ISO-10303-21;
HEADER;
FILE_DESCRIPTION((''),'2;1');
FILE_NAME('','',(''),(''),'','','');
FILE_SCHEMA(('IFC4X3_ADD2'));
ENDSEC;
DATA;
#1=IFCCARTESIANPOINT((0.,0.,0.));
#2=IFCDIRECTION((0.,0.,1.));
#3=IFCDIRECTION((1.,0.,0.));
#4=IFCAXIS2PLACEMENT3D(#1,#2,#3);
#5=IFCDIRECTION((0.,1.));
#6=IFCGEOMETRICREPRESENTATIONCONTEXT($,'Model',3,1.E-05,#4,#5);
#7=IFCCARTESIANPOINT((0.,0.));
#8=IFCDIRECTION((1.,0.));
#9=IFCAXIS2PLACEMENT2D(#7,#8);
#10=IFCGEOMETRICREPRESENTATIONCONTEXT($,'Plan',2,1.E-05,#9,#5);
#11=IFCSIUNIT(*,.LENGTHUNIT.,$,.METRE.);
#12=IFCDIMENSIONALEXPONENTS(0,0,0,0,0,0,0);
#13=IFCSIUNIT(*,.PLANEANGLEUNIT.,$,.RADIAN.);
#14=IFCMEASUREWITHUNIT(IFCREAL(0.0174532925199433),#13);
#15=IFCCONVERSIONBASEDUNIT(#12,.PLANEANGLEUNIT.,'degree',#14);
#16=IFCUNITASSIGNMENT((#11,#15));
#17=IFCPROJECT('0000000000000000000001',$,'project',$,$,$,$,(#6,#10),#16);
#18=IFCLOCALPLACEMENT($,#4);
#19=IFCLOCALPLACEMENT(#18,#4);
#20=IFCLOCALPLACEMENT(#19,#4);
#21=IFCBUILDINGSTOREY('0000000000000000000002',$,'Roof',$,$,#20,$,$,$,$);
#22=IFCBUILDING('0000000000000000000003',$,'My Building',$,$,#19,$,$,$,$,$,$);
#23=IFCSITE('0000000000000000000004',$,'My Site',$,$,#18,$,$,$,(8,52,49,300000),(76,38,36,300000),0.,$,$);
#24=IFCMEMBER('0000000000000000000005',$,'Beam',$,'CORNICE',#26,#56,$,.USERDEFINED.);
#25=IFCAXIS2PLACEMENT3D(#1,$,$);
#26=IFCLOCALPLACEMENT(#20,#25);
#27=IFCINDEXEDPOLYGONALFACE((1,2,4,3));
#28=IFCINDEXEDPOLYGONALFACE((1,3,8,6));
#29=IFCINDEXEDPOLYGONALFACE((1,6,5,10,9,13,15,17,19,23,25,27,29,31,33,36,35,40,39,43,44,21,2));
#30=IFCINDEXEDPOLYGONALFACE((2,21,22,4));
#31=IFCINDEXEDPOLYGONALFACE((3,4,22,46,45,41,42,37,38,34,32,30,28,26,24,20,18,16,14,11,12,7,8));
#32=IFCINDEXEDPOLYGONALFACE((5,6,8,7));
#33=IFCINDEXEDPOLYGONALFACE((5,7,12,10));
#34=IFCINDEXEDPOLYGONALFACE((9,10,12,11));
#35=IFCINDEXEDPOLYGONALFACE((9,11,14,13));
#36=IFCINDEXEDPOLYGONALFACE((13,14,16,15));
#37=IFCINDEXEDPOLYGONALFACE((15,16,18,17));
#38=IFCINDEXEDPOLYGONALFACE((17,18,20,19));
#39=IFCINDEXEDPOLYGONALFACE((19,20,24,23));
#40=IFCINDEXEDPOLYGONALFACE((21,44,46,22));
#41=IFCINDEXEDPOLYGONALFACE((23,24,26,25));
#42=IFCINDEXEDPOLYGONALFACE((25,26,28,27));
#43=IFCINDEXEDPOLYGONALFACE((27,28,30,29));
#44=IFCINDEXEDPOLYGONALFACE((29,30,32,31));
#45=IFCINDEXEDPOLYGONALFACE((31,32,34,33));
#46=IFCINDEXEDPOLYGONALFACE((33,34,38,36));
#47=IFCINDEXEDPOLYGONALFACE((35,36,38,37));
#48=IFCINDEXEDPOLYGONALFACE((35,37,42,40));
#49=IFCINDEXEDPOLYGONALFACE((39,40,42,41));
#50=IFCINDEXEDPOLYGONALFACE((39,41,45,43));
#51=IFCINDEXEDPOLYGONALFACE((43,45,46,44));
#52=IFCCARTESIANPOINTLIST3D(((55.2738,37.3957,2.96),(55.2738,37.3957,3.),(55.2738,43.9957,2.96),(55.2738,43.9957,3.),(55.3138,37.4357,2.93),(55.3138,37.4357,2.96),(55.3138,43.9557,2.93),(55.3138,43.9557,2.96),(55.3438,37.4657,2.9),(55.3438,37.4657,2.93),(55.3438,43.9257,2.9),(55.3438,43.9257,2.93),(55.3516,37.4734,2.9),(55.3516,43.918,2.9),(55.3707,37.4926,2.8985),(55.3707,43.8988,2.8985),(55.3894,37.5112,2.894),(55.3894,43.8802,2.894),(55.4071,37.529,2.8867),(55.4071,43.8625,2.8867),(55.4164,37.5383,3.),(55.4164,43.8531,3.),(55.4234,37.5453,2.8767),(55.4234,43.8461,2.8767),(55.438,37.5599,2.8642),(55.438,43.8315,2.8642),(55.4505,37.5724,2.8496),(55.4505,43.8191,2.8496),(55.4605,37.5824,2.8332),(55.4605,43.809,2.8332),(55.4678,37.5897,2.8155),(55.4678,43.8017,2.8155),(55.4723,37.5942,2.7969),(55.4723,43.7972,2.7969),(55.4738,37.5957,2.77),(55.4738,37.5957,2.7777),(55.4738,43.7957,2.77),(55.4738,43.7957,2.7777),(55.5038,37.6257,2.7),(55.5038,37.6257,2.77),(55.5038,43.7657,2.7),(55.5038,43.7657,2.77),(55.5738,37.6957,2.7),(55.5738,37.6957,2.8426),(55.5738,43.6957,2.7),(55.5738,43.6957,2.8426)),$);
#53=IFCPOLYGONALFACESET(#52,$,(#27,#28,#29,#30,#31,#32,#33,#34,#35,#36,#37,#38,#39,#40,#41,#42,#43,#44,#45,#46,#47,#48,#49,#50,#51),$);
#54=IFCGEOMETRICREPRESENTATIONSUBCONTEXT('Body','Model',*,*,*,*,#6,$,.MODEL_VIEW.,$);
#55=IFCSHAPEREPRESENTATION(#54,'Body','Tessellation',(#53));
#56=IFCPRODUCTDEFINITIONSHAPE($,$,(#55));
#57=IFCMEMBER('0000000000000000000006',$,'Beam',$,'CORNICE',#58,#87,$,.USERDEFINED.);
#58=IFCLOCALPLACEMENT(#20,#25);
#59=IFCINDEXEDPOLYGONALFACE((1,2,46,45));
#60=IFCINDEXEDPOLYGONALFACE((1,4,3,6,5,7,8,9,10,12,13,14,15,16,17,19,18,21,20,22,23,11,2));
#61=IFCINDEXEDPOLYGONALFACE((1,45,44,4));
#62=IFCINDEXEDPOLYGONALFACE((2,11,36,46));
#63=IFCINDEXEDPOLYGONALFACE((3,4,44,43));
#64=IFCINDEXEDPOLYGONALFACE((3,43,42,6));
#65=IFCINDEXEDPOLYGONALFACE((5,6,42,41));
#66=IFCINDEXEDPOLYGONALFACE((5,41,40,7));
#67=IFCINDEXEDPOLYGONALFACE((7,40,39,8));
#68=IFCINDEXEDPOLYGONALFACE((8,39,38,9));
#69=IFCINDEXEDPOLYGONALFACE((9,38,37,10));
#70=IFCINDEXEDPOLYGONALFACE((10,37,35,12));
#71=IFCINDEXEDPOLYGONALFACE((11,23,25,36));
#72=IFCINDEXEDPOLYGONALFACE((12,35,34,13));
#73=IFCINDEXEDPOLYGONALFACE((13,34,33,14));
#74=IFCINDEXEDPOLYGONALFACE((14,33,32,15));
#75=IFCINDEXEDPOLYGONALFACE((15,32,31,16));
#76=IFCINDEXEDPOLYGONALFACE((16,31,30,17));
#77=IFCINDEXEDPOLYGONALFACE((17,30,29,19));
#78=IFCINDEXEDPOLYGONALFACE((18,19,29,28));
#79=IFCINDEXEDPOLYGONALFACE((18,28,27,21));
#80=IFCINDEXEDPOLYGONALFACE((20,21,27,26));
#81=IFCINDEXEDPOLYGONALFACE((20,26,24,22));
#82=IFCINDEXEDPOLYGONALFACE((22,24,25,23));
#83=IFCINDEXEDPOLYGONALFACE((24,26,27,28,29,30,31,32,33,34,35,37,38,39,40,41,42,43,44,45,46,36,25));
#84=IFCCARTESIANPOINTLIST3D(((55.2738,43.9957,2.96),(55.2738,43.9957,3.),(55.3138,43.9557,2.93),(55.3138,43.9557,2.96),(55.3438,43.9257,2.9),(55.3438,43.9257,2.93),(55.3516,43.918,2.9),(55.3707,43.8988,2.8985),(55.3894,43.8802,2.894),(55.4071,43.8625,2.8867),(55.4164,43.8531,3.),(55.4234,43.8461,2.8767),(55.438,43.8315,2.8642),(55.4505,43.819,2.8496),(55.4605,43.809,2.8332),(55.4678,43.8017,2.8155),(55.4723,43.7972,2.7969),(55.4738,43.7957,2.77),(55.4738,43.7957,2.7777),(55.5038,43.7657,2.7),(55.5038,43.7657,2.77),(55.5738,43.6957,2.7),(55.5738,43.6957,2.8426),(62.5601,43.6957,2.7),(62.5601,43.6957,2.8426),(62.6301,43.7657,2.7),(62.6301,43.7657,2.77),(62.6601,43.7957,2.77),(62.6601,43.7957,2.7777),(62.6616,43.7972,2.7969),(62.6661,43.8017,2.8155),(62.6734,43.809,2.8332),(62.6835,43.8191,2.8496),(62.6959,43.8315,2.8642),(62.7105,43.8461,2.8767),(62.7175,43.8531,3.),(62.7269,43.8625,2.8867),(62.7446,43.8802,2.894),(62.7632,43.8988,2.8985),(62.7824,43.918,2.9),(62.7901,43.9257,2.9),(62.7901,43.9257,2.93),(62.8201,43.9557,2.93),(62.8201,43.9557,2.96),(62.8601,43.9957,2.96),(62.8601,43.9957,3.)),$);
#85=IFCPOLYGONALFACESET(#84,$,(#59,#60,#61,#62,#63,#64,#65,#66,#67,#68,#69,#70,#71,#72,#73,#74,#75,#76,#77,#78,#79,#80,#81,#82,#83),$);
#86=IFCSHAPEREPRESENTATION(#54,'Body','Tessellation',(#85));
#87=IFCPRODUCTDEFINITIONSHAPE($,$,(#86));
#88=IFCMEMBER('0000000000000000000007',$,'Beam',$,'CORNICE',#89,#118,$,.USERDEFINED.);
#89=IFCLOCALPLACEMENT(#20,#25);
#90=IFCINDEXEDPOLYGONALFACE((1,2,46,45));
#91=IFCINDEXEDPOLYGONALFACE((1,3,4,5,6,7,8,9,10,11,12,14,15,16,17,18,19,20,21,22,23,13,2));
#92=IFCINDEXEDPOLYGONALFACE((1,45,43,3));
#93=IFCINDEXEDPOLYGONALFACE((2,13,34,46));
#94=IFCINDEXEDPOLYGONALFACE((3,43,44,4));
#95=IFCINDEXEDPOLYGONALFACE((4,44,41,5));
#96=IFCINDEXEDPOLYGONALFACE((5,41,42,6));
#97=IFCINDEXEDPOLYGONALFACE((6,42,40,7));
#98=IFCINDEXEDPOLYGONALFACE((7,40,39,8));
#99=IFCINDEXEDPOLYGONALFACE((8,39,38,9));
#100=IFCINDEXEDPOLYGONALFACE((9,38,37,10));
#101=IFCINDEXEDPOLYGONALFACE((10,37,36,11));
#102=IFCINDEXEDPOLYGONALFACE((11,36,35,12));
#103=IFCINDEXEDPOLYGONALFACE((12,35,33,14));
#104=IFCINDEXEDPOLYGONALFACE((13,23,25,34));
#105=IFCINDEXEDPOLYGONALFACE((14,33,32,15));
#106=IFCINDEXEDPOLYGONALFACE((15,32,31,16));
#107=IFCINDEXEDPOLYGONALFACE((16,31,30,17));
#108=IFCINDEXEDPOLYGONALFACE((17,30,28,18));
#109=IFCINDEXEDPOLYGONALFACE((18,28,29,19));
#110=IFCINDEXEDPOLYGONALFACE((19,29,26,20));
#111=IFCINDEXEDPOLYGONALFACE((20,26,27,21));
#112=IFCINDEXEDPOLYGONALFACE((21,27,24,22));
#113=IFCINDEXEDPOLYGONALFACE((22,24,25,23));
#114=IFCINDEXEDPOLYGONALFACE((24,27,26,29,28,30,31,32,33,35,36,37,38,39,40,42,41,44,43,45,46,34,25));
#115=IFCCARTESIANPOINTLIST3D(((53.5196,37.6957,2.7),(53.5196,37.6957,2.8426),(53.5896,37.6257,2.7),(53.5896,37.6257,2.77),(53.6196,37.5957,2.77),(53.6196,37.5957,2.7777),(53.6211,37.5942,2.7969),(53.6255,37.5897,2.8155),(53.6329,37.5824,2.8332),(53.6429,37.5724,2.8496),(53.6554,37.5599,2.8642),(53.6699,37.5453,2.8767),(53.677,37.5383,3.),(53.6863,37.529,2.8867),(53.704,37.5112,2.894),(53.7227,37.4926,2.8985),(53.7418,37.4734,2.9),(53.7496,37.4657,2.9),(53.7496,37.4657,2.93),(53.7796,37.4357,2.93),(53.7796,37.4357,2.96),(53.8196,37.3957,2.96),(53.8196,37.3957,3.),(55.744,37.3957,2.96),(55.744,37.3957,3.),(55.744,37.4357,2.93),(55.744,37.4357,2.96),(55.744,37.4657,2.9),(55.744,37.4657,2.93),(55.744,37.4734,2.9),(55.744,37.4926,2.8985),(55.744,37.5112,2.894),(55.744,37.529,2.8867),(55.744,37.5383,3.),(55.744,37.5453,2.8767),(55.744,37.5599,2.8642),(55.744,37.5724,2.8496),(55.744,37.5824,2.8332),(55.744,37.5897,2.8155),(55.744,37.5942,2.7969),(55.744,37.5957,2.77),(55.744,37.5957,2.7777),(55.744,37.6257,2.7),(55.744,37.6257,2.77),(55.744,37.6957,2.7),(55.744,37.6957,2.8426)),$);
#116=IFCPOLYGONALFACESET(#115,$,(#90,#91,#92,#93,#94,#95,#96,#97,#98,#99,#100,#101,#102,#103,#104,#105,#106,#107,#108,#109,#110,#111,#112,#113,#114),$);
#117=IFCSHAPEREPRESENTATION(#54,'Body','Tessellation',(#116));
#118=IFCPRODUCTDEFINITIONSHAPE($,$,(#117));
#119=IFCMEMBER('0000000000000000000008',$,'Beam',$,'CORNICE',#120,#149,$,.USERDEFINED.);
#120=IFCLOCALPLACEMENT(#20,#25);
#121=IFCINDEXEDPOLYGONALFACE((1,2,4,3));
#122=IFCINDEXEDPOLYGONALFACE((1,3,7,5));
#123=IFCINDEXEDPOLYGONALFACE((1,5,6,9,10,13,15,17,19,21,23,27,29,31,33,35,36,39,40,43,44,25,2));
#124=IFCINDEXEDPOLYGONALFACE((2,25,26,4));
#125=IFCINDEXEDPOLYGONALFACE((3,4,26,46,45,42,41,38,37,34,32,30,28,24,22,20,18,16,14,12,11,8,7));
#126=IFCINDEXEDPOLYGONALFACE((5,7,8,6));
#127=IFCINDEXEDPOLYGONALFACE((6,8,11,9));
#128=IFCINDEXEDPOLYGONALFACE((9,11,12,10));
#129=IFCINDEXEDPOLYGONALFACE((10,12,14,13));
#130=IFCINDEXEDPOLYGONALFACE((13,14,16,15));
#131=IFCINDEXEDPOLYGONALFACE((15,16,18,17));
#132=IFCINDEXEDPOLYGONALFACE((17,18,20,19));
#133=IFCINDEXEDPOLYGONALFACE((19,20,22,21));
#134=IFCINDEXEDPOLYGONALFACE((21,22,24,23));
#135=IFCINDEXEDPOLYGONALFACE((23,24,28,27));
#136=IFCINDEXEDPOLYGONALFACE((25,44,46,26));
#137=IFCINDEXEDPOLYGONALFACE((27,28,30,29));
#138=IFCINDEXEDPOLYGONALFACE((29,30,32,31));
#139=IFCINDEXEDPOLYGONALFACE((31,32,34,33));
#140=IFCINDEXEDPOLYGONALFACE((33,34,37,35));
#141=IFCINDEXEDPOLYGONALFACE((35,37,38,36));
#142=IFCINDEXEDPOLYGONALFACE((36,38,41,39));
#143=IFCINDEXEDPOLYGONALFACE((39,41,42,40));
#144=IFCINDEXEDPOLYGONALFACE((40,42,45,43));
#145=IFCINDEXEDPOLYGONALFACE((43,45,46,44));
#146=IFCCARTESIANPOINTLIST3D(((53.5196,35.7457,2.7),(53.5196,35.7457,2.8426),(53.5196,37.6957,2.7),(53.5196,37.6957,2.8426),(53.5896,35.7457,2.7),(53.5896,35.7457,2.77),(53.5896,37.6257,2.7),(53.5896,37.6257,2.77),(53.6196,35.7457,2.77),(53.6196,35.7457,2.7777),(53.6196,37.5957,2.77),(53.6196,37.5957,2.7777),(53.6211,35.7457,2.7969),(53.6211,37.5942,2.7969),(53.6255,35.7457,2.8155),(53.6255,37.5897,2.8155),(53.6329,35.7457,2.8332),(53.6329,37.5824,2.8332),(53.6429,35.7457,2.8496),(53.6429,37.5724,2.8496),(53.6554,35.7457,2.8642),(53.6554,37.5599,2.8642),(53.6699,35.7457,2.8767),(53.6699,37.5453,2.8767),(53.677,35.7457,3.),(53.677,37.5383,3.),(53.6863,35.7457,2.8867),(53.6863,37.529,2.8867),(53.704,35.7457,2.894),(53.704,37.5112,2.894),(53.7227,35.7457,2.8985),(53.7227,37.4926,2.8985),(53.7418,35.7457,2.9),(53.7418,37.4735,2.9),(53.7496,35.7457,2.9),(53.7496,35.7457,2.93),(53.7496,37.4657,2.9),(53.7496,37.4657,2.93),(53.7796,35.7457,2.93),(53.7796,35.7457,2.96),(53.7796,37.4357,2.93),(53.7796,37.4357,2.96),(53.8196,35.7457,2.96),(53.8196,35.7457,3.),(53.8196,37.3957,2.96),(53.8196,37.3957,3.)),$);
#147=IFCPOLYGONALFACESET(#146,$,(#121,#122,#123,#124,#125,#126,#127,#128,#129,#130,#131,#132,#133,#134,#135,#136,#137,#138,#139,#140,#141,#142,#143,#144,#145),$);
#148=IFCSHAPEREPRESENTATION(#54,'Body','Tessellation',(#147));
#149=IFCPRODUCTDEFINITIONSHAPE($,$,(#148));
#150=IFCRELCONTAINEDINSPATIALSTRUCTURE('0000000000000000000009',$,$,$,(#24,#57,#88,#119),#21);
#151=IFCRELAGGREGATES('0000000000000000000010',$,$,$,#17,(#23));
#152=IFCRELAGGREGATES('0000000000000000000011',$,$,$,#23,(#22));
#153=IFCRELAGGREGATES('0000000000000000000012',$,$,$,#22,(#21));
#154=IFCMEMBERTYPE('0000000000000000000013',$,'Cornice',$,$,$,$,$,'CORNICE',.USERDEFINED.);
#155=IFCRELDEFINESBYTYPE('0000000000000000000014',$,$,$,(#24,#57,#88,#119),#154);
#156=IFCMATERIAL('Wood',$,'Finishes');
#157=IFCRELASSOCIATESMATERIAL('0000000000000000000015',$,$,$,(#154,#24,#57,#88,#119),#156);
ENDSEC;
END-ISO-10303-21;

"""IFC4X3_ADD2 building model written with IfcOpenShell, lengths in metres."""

from ifc_helpers import new_model, entity, si_unit, converted_unit, direction, frame, origin_with_axes, origin_2d_with_axis, place, context, subcontext, project, spatial, indexed_curve, outline, extrude, clip, halfspace, material, material_profile, profile_set, profile_usage, type_object, element, save


model = new_model("IFC4X3_ADD2")

# Units and contexts
model_context = context("Model", 3, precision=1e-05, world=origin_with_axes(), true_north=direction((0.0, 1.0)))
plan_context = context("Plan", 2, precision=1e-05, world=origin_2d_with_axis(), true_north=direction((0.0, 1.0)))
body_context = subcontext(model_context, "Body", "Model", "MODEL_VIEW")
ifc_project = project(units=[si_unit("LENGTHUNIT", "METRE"), converted_unit("PLANEANGLEUNIT", "degree", entity("IfcReal", 0.0174532925199433), si_unit("PLANEANGLEUNIT", "RADIAN"), dimensions=[0, 0, 0, 0, 0, 0, 0])], contexts=[model_context, plan_context])

# Site, building, storey
site_placement = place(None, origin_with_axes())
site = spatial("IfcSite", under=ifc_project, at=site_placement, Name="My Site", RefLatitude=(8, 52, 49, 300000), RefLongitude=(76, 38, 36, 300000), RefElevation=0.0)
building_placement = place(site_placement, origin_with_axes())
building = spatial("IfcBuilding", under=site, at=building_placement, Name="My Building")
storey_placement = place(building_placement, origin_with_axes())
storey = spatial("IfcBuildingStorey", under=building, at=storey_placement, Name="Roof")

# Members
ifc_material_1 = material(Name="Wood", Category="Finishes")
ifc_material_profile_1 = material_profile(ifc_material_1, outline(indexed_curve([(-0.26, 0.26), (-0.3, 0.26), (-0.3, 0.3), (-0.1574, 0.3), (0.0, 0.1426), (0.0, 0.0), (-0.07, 0.0), (-0.07, 0.07), (-0.1, 0.07), (-0.1, 0.0777), (-0.1015, 0.0969), (-0.106, 0.1155), (-0.1133, 0.1332), (-0.1233, 0.1496), (-0.1358, 0.1642), (-0.1504, 0.1767), (-0.1668, 0.1867), (-0.1845, 0.194), (-0.2031, 0.1985), (-0.2223, 0.2), (-0.23, 0.2), (-0.23, 0.23), (-0.26, 0.23), (-0.26, 0.26)])))
ifc_profile_set_1 = profile_set([ifc_material_profile_1])
member_type = type_object("IfcMemberType", Name="Cornice", ElementType="CORNICE", PredefinedType="USERDEFINED", material=ifc_profile_set_1)
ifc_profile_usage_1 = profile_usage(ifc_profile_set_1, cardinal=5)
member_1_placement = place(storey_placement, frame((55.5738, 43.9957, 2.7), z_axis=(0.0, -1.0, 0.0), x_axis=(1.0, 0.0, 0.0)))
element("IfcMember", 1, at=member_1_placement, inside=storey, type_object=member_type, material=ifc_profile_usage_1, Name="Beam", ObjectType="CORNICE", PredefinedType="USERDEFINED", context=body_context, shape_type="Clipping", body=[
    clip(clip(extrude(outline(indexed_curve([(-0.26, 0.26), (-0.3, 0.26), (-0.3, 0.3), (-0.1574, 0.3), (0.0, 0.1426), (0.0, 0.0), (-0.07, 0.0), (-0.07, 0.07), (-0.1, 0.07), (-0.1, 0.0777), (-0.1015, 0.0969), (-0.106, 0.1155), (-0.1133, 0.1332), (-0.1233, 0.1496), (-0.1358, 0.1642), (-0.1504, 0.1767), (-0.1668, 0.1867), (-0.1845, 0.194), (-0.2031, 0.1985), (-0.2223, 0.2), (-0.23, 0.2), (-0.23, 0.23), (-0.26, 0.23), (-0.26, 0.26)])), origin_with_axes(), (0.0, 0.0, 1.0), 6.6), halfspace(frame((-0.3, -2.7, 0.0), z_axis=(0.707107, 0.0, -0.707107), x_axis=(0.0, -1.0, 0.0)), False)), halfspace(frame((-0.3, -2.7, 6.6), z_axis=(0.707107, 0.0, 0.707107), x_axis=(0.0, -1.0, 0.0)), False)),
])
ifc_profile_usage_2 = profile_usage(ifc_profile_set_1, cardinal=5)
member_2_placement = place(storey_placement, frame((62.8601, 43.6957, 2.7), z_axis=(-1.0, 0.0, 0.0), x_axis=(0.0, -1.0, 0.0)))
element("IfcMember", 2, at=member_2_placement, inside=storey, type_object=member_type, material=ifc_profile_usage_2, Name="Beam", ObjectType="CORNICE", PredefinedType="USERDEFINED", context=body_context, shape_type="Clipping", body=[
    clip(clip(extrude(outline(indexed_curve([(-0.26, 0.26), (-0.3, 0.26), (-0.3, 0.3), (-0.1574, 0.3), (0.0, 0.1426), (0.0, 0.0), (-0.07, 0.0), (-0.07, 0.07), (-0.1, 0.07), (-0.1, 0.0777), (-0.1015, 0.0969), (-0.106, 0.1155), (-0.1133, 0.1332), (-0.1233, 0.1496), (-0.1358, 0.1642), (-0.1504, 0.1767), (-0.1668, 0.1867), (-0.1845, 0.194), (-0.2031, 0.1985), (-0.2223, 0.2), (-0.23, 0.2), (-0.23, 0.23), (-0.26, 0.23), (-0.26, 0.26)])), origin_with_axes(), (0.0, 0.0, 1.0), 7.5863), halfspace(frame((-0.3, -2.7, 0.0), z_axis=(0.707107, 0.0, -0.707107), x_axis=(0.0, -1.0, 0.0)), False)), halfspace(frame((-0.3, -2.7, 7.5863), z_axis=(0.707107, 0.0, 0.707107), x_axis=(0.0, -1.0, 0.0)), False)),
])
ifc_profile_usage_3 = profile_usage(ifc_profile_set_1, cardinal=5)
member_3_placement = place(storey_placement, frame((53.5196, 37.6957, 2.7), z_axis=(1.0, 0.0, 0.0), x_axis=(0.0, 1.0, 0.0)))
element("IfcMember", 3, at=member_3_placement, inside=storey, type_object=member_type, material=ifc_profile_usage_3, Name="Beam", ObjectType="CORNICE", PredefinedType="USERDEFINED", context=body_context, shape_type="Clipping", body=[
    clip(extrude(outline(indexed_curve([(-0.26, 0.26), (-0.3, 0.26), (-0.3, 0.3), (-0.1574, 0.3), (0.0, 0.1426), (0.0, 0.0), (-0.07, 0.0), (-0.07, 0.07), (-0.1, 0.07), (-0.1, 0.0777), (-0.1015, 0.0969), (-0.106, 0.1155), (-0.1133, 0.1332), (-0.1233, 0.1496), (-0.1358, 0.1642), (-0.1504, 0.1767), (-0.1668, 0.1867), (-0.1845, 0.194), (-0.2031, 0.1985), (-0.2223, 0.2), (-0.23, 0.2), (-0.23, 0.23), (-0.26, 0.23), (-0.26, 0.26)])), origin_with_axes(), (0.0, 0.0, 1.0), 2.2245), halfspace(frame((0.0, -2.7, 0.0), z_axis=(-0.707107, 0.0, -0.707107), x_axis=(0.0, 1.0, 0.0)), False)),
])
ifc_profile_usage_4 = profile_usage(ifc_profile_set_1, cardinal=5)
member_4_placement = place(storey_placement, frame((53.5196, 35.7457, 2.7), z_axis=(0.0, 1.0, 0.0), x_axis=(-1.0, 0.0, 0.0)))
element("IfcMember", 4, at=member_4_placement, inside=storey, type_object=member_type, material=ifc_profile_usage_4, Name="Beam", ObjectType="CORNICE", PredefinedType="USERDEFINED", context=body_context, shape_type="Clipping", body=[
    clip(extrude(outline(indexed_curve([(-0.26, 0.26), (-0.3, 0.26), (-0.3, 0.3), (-0.1574, 0.3), (0.0, 0.1426), (0.0, 0.0), (-0.07, 0.0), (-0.07, 0.07), (-0.1, 0.07), (-0.1, 0.0777), (-0.1015, 0.0969), (-0.106, 0.1155), (-0.1133, 0.1332), (-0.1233, 0.1496), (-0.1358, 0.1642), (-0.1504, 0.1767), (-0.1668, 0.1867), (-0.1845, 0.194), (-0.2031, 0.1985), (-0.2223, 0.2), (-0.23, 0.2), (-0.23, 0.23), (-0.26, 0.23), (-0.26, 0.26)])), origin_with_axes(), (0.0, 0.0, 1.0), 1.95), halfspace(frame((0.0, -2.7, 1.95), z_axis=(-0.707107, 0.0, 0.707107), x_axis=(0.0, 1.0, 0.0)), False)),
])

save(model, "model.ifc")
